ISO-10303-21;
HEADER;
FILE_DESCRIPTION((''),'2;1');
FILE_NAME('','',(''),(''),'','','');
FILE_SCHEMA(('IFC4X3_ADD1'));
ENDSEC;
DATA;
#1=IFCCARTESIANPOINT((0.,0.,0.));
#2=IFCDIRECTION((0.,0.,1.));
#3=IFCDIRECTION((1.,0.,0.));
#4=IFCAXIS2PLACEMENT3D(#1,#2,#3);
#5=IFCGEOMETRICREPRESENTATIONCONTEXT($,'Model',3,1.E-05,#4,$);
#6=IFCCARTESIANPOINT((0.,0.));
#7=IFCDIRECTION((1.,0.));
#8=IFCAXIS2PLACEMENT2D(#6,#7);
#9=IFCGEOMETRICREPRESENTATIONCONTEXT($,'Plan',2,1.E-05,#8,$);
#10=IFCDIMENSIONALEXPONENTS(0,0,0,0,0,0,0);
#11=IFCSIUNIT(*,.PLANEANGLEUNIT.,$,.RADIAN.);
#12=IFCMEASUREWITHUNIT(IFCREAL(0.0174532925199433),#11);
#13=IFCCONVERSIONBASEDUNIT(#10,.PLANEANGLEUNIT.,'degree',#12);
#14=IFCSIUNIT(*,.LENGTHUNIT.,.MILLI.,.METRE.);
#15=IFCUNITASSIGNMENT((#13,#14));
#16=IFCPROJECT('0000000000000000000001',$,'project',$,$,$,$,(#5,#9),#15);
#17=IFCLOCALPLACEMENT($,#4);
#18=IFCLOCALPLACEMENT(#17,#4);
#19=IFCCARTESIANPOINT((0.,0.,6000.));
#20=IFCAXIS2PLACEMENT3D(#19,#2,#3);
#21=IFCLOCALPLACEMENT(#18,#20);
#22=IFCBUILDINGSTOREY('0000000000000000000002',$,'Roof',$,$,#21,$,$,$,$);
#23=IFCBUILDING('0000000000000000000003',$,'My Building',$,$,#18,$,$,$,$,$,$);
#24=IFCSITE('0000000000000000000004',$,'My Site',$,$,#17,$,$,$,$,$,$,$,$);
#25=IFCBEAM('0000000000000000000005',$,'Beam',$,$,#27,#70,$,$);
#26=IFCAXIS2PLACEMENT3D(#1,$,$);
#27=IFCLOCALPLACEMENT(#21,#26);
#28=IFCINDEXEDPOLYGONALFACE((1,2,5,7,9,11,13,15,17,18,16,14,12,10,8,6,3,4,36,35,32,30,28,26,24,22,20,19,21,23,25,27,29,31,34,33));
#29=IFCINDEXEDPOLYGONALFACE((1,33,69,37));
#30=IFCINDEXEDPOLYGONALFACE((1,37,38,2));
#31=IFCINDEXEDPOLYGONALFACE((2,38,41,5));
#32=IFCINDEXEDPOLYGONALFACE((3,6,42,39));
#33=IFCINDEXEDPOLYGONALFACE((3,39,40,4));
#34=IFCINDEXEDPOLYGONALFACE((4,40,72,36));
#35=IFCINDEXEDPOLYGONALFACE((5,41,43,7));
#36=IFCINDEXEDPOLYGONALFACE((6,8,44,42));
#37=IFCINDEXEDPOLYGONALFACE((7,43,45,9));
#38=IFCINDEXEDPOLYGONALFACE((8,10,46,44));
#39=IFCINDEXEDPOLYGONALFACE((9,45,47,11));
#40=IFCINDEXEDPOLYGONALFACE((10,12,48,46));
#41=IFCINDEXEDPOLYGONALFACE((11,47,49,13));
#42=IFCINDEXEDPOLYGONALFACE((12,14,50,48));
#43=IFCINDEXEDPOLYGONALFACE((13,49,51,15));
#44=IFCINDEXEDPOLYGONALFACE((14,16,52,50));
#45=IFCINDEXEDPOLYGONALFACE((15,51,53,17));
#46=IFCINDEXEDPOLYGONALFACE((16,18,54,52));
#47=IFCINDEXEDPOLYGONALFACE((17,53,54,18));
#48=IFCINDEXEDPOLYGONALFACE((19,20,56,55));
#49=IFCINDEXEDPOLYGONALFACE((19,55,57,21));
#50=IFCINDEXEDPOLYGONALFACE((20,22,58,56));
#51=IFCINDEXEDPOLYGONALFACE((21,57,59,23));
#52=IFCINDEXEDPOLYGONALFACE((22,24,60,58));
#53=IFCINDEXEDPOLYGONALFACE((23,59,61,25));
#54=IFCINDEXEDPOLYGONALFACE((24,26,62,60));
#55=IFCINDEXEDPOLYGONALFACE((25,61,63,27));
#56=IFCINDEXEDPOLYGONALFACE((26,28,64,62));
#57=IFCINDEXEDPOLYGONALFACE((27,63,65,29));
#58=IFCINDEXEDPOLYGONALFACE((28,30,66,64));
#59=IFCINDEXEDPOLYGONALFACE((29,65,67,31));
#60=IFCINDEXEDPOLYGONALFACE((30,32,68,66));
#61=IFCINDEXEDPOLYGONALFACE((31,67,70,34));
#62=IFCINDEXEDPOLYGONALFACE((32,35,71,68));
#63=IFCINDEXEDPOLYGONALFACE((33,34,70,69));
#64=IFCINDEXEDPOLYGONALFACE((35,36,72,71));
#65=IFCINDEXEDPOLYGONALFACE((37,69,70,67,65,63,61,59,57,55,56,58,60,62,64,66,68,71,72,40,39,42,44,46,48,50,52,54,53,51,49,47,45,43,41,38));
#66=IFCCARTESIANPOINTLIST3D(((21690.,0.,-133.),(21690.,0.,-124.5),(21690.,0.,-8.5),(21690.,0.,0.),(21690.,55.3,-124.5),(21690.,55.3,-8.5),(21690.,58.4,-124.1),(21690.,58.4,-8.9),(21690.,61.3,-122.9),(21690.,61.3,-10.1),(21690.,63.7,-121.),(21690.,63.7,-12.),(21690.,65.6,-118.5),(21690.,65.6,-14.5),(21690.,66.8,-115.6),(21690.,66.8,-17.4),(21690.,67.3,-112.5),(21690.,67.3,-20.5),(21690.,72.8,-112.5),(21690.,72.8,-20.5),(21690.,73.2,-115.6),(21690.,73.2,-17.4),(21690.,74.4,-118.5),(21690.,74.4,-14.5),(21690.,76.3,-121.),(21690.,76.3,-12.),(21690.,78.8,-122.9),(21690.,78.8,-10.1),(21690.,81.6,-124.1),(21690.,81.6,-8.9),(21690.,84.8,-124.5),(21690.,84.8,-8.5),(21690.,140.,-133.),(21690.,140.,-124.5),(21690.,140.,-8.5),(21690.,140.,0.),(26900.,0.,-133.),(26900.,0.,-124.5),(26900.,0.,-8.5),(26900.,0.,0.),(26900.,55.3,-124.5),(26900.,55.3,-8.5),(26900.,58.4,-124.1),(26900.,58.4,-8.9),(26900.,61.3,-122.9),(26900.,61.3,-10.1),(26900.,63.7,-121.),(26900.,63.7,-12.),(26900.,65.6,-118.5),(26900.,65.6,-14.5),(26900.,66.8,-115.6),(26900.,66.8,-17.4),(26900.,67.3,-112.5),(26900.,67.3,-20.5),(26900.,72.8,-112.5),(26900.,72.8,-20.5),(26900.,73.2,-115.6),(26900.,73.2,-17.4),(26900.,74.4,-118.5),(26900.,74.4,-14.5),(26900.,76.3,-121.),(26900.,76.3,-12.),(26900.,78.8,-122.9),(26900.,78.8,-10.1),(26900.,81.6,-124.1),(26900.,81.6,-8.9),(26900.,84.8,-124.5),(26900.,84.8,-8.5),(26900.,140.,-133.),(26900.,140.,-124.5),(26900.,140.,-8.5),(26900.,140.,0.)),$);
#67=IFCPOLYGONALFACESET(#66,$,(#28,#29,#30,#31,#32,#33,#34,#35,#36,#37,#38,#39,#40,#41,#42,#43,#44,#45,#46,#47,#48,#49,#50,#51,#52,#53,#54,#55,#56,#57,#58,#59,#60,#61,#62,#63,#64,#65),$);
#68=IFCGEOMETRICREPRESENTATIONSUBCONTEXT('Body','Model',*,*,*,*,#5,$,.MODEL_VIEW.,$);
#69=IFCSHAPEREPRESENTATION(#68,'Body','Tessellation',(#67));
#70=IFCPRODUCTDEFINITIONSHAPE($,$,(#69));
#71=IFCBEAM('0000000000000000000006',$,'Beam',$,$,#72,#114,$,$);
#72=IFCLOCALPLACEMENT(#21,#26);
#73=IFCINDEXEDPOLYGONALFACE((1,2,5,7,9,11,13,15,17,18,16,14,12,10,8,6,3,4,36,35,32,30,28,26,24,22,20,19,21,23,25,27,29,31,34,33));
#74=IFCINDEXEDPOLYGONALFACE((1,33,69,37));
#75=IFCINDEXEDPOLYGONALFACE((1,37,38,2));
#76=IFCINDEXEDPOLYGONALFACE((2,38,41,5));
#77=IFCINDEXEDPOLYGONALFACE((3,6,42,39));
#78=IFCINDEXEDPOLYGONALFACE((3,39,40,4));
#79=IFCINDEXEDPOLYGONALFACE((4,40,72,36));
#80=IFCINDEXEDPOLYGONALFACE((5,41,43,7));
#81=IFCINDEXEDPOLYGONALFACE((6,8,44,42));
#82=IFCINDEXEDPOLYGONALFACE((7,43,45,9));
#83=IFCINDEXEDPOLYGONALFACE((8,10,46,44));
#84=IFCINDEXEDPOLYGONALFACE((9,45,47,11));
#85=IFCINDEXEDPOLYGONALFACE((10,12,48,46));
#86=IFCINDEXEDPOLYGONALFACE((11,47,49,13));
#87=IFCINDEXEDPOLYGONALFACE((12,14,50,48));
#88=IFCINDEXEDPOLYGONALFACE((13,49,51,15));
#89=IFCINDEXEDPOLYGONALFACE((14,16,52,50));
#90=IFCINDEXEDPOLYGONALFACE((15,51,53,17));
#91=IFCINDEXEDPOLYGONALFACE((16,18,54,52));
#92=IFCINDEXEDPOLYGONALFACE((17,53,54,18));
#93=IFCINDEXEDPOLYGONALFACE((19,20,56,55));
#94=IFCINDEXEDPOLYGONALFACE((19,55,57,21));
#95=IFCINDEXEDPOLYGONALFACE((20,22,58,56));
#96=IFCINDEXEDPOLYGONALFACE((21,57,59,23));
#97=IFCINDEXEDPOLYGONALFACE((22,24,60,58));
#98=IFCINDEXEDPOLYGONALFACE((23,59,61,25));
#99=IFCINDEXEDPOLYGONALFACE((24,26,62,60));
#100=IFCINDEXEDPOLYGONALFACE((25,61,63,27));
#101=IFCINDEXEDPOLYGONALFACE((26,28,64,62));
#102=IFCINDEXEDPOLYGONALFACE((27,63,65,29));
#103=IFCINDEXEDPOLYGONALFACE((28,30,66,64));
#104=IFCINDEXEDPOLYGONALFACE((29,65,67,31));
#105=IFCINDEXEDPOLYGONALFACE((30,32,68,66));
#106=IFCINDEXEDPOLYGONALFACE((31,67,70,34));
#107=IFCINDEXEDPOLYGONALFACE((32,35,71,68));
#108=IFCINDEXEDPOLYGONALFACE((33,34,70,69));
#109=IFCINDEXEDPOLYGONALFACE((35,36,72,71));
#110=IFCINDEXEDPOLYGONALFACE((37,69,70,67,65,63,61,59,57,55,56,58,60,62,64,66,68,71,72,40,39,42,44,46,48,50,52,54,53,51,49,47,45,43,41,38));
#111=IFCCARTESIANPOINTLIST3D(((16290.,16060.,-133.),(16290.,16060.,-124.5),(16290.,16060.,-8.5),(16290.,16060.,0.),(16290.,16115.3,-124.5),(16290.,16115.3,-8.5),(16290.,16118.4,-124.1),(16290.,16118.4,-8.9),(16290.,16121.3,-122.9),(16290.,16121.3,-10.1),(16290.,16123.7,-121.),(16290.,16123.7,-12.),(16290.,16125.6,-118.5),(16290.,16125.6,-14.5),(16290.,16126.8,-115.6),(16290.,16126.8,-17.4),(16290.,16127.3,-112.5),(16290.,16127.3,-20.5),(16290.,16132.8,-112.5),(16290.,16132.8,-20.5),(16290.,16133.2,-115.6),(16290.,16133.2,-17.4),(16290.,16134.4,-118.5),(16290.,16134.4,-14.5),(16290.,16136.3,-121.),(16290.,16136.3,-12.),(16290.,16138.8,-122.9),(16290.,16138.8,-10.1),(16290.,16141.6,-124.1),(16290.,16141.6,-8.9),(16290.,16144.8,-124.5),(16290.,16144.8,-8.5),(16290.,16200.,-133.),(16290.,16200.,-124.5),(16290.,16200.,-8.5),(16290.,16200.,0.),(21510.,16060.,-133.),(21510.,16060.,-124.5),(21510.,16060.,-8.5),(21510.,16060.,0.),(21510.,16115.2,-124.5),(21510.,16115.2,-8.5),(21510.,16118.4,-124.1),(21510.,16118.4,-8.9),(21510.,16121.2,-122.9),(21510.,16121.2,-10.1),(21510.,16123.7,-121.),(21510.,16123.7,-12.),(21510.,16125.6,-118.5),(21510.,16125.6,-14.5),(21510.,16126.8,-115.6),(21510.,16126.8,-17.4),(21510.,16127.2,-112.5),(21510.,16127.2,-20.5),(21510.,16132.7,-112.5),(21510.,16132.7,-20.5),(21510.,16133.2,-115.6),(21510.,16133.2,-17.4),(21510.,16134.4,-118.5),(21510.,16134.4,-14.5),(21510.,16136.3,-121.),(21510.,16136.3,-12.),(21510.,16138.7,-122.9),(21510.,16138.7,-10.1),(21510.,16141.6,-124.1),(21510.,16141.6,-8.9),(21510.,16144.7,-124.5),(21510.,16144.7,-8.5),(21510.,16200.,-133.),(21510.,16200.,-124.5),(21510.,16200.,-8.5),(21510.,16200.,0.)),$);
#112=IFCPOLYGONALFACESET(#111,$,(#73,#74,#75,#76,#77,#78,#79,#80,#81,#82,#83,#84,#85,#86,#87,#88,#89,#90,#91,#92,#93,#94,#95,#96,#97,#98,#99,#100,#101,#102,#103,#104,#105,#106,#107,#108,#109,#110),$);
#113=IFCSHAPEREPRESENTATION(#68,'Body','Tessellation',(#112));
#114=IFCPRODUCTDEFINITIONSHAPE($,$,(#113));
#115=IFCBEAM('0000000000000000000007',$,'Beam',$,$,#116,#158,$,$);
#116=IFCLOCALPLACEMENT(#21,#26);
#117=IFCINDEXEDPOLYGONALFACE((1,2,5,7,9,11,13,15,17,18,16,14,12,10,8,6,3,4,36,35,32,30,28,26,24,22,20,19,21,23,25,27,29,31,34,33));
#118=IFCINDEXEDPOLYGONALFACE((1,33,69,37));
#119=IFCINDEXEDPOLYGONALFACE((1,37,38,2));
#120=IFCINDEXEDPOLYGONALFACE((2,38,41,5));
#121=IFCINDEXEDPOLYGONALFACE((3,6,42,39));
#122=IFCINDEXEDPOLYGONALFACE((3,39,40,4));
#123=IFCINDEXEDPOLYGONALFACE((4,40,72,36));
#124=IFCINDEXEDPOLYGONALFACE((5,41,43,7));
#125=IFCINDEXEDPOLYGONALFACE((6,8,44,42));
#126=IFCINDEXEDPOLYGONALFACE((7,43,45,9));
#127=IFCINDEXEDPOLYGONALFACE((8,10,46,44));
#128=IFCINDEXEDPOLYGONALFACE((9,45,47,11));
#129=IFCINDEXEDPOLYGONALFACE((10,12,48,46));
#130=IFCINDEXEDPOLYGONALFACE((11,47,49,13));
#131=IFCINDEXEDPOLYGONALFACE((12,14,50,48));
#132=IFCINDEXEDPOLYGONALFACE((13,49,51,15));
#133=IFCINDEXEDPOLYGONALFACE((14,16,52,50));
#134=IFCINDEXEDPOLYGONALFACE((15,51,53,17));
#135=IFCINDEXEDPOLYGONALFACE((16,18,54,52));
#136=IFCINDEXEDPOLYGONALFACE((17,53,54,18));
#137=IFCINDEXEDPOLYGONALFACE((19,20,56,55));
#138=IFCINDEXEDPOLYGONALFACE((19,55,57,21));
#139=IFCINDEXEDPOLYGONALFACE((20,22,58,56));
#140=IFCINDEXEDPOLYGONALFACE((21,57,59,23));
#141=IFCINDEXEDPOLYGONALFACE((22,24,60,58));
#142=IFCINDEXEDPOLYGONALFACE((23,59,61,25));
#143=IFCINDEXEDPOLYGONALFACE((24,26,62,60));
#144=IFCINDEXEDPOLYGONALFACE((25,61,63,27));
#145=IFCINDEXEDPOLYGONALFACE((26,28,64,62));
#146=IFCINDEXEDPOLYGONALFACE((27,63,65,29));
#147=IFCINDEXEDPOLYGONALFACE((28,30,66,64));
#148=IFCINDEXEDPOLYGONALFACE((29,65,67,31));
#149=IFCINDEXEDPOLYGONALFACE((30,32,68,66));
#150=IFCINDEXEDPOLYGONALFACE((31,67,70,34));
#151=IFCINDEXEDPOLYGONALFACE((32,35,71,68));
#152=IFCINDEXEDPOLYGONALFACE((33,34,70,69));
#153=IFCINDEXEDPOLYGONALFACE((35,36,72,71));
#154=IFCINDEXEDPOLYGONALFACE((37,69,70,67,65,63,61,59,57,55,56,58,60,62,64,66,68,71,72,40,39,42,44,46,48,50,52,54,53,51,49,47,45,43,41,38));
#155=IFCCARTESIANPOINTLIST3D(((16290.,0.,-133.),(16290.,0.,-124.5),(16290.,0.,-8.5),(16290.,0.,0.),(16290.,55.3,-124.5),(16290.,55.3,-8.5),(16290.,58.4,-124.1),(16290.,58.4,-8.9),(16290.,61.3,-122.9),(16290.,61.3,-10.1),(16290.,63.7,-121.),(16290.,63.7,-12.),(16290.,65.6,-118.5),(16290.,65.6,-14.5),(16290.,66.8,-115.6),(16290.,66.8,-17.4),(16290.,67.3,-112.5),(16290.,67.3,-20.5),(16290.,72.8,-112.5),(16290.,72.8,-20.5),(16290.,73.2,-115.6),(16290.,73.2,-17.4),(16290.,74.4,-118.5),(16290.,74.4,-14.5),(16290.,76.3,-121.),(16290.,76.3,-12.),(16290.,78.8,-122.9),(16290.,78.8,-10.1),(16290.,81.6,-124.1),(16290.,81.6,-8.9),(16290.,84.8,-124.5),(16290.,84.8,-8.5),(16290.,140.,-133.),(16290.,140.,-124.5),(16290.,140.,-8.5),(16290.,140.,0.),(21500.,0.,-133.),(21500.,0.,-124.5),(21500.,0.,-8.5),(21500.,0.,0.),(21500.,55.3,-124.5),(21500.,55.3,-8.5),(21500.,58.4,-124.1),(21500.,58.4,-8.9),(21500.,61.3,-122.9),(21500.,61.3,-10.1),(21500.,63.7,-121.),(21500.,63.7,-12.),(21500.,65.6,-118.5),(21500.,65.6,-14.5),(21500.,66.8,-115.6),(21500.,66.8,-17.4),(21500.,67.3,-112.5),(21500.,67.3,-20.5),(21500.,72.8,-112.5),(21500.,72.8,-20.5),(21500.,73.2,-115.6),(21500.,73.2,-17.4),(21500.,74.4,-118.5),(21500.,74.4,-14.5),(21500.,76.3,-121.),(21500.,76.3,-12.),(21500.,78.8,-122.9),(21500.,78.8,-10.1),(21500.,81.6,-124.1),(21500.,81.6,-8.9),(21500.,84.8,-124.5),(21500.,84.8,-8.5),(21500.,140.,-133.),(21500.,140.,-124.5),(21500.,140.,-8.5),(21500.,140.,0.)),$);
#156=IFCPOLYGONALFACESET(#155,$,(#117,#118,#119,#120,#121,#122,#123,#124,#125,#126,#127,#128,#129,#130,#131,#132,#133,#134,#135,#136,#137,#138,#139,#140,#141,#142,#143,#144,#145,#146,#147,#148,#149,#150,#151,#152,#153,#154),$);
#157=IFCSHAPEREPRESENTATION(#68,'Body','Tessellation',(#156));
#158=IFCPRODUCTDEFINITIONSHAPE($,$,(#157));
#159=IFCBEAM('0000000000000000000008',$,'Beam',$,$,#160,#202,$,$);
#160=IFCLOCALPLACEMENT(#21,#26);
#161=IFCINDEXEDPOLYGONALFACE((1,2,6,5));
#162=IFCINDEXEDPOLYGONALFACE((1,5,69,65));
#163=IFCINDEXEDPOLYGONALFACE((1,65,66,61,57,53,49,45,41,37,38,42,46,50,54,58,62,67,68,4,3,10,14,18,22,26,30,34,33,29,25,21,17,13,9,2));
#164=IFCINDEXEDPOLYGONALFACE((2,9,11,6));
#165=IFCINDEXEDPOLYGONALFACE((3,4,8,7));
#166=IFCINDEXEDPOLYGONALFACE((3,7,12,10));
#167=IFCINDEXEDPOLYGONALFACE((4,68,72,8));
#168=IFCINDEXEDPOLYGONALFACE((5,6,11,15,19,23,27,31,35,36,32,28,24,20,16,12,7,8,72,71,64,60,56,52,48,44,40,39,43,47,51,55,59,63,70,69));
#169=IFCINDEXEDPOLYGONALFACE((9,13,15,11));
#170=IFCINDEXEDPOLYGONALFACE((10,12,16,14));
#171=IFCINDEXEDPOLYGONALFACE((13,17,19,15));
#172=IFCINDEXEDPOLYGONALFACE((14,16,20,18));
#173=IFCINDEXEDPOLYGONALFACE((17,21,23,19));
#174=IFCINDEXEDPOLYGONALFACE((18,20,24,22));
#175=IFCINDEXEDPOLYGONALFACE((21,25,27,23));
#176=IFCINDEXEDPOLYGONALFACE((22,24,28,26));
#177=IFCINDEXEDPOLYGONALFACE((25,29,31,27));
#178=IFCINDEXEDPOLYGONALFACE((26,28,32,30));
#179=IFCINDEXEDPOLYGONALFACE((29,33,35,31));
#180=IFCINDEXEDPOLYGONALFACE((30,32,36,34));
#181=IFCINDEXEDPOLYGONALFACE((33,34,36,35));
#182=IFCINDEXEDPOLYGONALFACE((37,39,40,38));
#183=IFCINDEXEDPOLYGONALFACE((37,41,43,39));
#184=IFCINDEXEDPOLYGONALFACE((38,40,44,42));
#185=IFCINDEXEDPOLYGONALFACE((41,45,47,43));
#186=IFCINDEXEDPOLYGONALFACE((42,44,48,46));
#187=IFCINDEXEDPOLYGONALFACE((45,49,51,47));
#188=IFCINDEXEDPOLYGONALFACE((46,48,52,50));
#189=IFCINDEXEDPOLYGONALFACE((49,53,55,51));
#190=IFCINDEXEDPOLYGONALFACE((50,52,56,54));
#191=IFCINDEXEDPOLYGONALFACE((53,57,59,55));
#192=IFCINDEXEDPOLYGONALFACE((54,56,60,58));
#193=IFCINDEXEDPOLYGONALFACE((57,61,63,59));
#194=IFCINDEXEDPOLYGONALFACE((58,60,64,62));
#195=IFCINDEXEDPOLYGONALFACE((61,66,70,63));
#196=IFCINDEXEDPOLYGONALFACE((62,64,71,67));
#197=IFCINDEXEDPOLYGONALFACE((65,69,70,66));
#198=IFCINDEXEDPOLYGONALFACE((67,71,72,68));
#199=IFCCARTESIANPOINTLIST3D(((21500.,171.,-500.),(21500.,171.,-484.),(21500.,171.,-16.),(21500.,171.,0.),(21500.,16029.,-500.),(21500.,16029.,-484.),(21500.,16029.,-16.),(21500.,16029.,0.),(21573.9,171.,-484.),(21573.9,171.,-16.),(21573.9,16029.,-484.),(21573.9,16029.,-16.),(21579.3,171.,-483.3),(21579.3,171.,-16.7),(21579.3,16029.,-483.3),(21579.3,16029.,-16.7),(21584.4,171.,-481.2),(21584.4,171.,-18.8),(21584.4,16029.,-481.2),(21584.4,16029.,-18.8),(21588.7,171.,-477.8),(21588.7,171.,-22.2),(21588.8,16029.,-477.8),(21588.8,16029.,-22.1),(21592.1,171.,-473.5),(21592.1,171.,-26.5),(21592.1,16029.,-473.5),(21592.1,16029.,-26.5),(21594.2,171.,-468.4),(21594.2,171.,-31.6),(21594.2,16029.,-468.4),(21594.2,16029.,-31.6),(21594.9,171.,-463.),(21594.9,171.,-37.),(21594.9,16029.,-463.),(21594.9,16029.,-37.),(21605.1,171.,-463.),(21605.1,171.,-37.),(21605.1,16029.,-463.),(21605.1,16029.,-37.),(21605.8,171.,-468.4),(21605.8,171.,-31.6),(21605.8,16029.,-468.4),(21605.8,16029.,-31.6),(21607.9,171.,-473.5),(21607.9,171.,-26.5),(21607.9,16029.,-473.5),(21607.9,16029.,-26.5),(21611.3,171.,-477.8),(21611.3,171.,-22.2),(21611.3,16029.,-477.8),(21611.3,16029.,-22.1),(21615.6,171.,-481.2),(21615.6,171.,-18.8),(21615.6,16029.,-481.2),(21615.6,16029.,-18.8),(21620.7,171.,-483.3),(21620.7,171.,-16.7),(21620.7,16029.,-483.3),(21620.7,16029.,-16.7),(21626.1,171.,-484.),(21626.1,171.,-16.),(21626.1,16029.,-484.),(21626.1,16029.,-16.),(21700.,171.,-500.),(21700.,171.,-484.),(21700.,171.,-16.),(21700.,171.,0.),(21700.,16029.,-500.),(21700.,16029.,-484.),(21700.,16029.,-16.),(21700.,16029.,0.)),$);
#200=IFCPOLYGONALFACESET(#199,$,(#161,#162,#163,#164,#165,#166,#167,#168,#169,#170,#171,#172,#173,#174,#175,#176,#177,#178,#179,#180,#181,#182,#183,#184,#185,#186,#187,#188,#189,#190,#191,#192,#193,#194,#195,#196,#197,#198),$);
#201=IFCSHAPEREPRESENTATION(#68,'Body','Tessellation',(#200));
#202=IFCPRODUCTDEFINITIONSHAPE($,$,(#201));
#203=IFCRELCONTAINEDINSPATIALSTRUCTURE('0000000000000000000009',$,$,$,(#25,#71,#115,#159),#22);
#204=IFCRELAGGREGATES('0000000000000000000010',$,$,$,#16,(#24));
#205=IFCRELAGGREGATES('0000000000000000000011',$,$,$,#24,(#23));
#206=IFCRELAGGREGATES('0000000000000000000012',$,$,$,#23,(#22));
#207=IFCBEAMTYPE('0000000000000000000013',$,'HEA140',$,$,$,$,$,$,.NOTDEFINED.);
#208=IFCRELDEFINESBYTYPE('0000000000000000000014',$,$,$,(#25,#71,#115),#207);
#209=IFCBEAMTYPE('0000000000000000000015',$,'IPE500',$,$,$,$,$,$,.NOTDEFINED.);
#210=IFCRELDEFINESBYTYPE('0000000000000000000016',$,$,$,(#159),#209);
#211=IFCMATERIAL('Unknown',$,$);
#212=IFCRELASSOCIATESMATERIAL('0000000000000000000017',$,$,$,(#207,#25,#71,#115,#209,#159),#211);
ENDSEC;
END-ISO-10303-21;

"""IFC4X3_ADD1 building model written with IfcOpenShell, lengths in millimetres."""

from ifc_helpers import new_model, entity, si_unit, converted_unit, frame, origin_with_axes, origin_2d_with_axis, place, context, subcontext, project, spatial, i_section, extrude, material, material_profile, profile_set, profile_usage, type_object, element, save


model = new_model("IFC4X3_ADD1")

# Units and contexts
model_context = context("Model", 3, precision=1e-05, world=origin_with_axes())
plan_context = context("Plan", 2, precision=1e-05, world=origin_2d_with_axis())
body_context = subcontext(model_context, "Body", "Model", "MODEL_VIEW")
ifc_project = project(units=[converted_unit("PLANEANGLEUNIT", "degree", entity("IfcReal", 0.0174532925199433), si_unit("PLANEANGLEUNIT", "RADIAN"), dimensions=[0, 0, 0, 0, 0, 0, 0]), si_unit("LENGTHUNIT", "METRE", prefix="MILLI")], contexts=[model_context, plan_context])

# Site, building, storey
site_placement = place(None, origin_with_axes())
site = spatial("IfcSite", under=ifc_project, at=site_placement, Name="My Site")
building_placement = place(site_placement, origin_with_axes())
building = spatial("IfcBuilding", under=site, at=building_placement, Name="My Building")
storey_placement = place(building_placement, frame((0.0, 0.0, 6000.0), z_axis=(0.0, 0.0, 1.0), x_axis=(1.0, 0.0, 0.0)))
storey = spatial("IfcBuildingStorey", under=building, at=storey_placement, Name="Roof")

# Beams
ifc_material = material(Name="Unknown")
ifc_material_profile_1 = material_profile(ifc_material, i_section(OverallWidth=140.0, OverallDepth=133.0, WebThickness=5.5, FlangeThickness=8.5, FilletRadius=12.0))
ifc_profile_set_1 = profile_set([ifc_material_profile_1])
beam_type_1 = type_object("IfcBeamType", Name="HEA140", PredefinedType="NOTDEFINED", material=ifc_profile_set_1)
ifc_profile_usage_1 = profile_usage(ifc_profile_set_1, cardinal=7)
beam_1_placement = place(storey_placement, frame((26900.0, 0.0, 0.0), z_axis=(-1.0, 0.0, 0.0), x_axis=(0.0, -1.0, 0.0)))
element("IfcBeam", 1, at=beam_1_placement, inside=storey, type_object=beam_type_1, material=ifc_profile_usage_1, Name="Beam", context=body_context, shape_type="SweptSolid", body=[
    extrude(i_section(OverallWidth=140.0, OverallDepth=133.0, WebThickness=5.5, FlangeThickness=8.5, FilletRadius=12.0), frame((-70.0, -66.5, 0.0), z_axis=(0.0, 0.0, 1.0), x_axis=(1.0, 0.0, 0.0)), (0.0, 0.0, 1.0), 5210.0),
])
ifc_profile_usage_2 = profile_usage(ifc_profile_set_1, cardinal=7)
beam_2_placement = place(storey_placement, frame((16290.0, 16200.0, 0.0), z_axis=(1.0, 0.0, 0.0), x_axis=(0.0, 1.0, 0.0)))
element("IfcBeam", 2, at=beam_2_placement, inside=storey, type_object=beam_type_1, material=ifc_profile_usage_2, Name="Beam", context=body_context, shape_type="SweptSolid", body=[
    extrude(i_section(OverallWidth=140.0, OverallDepth=133.0, WebThickness=5.5, FlangeThickness=8.5, FilletRadius=12.0), frame((-70.0, -66.5, 0.0), z_axis=(0.0, 0.0, 1.0), x_axis=(1.0, 0.0, 0.0)), (0.0, 0.0, 1.0), 5220.0),
])
ifc_profile_usage_3 = profile_usage(ifc_profile_set_1, cardinal=7)
beam_3_placement = place(storey_placement, frame((21500.0, 0.0, 0.0), z_axis=(-1.0, 0.0, 0.0), x_axis=(0.0, -1.0, 0.0)))
element("IfcBeam", 3, at=beam_3_placement, inside=storey, type_object=beam_type_1, material=ifc_profile_usage_3, Name="Beam", context=body_context, shape_type="SweptSolid", body=[
    extrude(i_section(OverallWidth=140.0, OverallDepth=133.0, WebThickness=5.5, FlangeThickness=8.5, FilletRadius=12.0), frame((-70.0, -66.5, 0.0), z_axis=(0.0, 0.0, 1.0), x_axis=(1.0, 0.0, 0.0)), (0.0, 0.0, 1.0), 5210.0),
])
ifc_material_profile_2 = material_profile(ifc_material, i_section(OverallWidth=200.0, OverallDepth=500.0, WebThickness=10.2, FlangeThickness=16.0, FilletRadius=21.0))
ifc_profile_set_2 = profile_set([ifc_material_profile_2])
ifc_profile_usage_4 = profile_usage(ifc_profile_set_2, cardinal=8)
beam_type_2 = type_object("IfcBeamType", Name="IPE500", PredefinedType="NOTDEFINED", material=ifc_profile_set_2)
beam_4_placement = place(storey_placement, frame((21600.0, 171.0, 0.0), z_axis=(0.0, 1.0, 0.0), x_axis=(-1.0, 0.0, 0.0)))
element("IfcBeam", 4, at=beam_4_placement, inside=storey, type_object=beam_type_2, material=ifc_profile_usage_4, Name="Beam", context=body_context, shape_type="SweptSolid", body=[
    extrude(i_section(OverallWidth=200.0, OverallDepth=500.0, WebThickness=10.2, FlangeThickness=16.0, FilletRadius=21.0), frame((0.0, -250.0, 0.0), z_axis=(0.0, 0.0, 1.0), x_axis=(1.0, 0.0, 0.0)), (0.0, 0.0, 1.0), 15858.0),
])

save(model, "model.ifc")
